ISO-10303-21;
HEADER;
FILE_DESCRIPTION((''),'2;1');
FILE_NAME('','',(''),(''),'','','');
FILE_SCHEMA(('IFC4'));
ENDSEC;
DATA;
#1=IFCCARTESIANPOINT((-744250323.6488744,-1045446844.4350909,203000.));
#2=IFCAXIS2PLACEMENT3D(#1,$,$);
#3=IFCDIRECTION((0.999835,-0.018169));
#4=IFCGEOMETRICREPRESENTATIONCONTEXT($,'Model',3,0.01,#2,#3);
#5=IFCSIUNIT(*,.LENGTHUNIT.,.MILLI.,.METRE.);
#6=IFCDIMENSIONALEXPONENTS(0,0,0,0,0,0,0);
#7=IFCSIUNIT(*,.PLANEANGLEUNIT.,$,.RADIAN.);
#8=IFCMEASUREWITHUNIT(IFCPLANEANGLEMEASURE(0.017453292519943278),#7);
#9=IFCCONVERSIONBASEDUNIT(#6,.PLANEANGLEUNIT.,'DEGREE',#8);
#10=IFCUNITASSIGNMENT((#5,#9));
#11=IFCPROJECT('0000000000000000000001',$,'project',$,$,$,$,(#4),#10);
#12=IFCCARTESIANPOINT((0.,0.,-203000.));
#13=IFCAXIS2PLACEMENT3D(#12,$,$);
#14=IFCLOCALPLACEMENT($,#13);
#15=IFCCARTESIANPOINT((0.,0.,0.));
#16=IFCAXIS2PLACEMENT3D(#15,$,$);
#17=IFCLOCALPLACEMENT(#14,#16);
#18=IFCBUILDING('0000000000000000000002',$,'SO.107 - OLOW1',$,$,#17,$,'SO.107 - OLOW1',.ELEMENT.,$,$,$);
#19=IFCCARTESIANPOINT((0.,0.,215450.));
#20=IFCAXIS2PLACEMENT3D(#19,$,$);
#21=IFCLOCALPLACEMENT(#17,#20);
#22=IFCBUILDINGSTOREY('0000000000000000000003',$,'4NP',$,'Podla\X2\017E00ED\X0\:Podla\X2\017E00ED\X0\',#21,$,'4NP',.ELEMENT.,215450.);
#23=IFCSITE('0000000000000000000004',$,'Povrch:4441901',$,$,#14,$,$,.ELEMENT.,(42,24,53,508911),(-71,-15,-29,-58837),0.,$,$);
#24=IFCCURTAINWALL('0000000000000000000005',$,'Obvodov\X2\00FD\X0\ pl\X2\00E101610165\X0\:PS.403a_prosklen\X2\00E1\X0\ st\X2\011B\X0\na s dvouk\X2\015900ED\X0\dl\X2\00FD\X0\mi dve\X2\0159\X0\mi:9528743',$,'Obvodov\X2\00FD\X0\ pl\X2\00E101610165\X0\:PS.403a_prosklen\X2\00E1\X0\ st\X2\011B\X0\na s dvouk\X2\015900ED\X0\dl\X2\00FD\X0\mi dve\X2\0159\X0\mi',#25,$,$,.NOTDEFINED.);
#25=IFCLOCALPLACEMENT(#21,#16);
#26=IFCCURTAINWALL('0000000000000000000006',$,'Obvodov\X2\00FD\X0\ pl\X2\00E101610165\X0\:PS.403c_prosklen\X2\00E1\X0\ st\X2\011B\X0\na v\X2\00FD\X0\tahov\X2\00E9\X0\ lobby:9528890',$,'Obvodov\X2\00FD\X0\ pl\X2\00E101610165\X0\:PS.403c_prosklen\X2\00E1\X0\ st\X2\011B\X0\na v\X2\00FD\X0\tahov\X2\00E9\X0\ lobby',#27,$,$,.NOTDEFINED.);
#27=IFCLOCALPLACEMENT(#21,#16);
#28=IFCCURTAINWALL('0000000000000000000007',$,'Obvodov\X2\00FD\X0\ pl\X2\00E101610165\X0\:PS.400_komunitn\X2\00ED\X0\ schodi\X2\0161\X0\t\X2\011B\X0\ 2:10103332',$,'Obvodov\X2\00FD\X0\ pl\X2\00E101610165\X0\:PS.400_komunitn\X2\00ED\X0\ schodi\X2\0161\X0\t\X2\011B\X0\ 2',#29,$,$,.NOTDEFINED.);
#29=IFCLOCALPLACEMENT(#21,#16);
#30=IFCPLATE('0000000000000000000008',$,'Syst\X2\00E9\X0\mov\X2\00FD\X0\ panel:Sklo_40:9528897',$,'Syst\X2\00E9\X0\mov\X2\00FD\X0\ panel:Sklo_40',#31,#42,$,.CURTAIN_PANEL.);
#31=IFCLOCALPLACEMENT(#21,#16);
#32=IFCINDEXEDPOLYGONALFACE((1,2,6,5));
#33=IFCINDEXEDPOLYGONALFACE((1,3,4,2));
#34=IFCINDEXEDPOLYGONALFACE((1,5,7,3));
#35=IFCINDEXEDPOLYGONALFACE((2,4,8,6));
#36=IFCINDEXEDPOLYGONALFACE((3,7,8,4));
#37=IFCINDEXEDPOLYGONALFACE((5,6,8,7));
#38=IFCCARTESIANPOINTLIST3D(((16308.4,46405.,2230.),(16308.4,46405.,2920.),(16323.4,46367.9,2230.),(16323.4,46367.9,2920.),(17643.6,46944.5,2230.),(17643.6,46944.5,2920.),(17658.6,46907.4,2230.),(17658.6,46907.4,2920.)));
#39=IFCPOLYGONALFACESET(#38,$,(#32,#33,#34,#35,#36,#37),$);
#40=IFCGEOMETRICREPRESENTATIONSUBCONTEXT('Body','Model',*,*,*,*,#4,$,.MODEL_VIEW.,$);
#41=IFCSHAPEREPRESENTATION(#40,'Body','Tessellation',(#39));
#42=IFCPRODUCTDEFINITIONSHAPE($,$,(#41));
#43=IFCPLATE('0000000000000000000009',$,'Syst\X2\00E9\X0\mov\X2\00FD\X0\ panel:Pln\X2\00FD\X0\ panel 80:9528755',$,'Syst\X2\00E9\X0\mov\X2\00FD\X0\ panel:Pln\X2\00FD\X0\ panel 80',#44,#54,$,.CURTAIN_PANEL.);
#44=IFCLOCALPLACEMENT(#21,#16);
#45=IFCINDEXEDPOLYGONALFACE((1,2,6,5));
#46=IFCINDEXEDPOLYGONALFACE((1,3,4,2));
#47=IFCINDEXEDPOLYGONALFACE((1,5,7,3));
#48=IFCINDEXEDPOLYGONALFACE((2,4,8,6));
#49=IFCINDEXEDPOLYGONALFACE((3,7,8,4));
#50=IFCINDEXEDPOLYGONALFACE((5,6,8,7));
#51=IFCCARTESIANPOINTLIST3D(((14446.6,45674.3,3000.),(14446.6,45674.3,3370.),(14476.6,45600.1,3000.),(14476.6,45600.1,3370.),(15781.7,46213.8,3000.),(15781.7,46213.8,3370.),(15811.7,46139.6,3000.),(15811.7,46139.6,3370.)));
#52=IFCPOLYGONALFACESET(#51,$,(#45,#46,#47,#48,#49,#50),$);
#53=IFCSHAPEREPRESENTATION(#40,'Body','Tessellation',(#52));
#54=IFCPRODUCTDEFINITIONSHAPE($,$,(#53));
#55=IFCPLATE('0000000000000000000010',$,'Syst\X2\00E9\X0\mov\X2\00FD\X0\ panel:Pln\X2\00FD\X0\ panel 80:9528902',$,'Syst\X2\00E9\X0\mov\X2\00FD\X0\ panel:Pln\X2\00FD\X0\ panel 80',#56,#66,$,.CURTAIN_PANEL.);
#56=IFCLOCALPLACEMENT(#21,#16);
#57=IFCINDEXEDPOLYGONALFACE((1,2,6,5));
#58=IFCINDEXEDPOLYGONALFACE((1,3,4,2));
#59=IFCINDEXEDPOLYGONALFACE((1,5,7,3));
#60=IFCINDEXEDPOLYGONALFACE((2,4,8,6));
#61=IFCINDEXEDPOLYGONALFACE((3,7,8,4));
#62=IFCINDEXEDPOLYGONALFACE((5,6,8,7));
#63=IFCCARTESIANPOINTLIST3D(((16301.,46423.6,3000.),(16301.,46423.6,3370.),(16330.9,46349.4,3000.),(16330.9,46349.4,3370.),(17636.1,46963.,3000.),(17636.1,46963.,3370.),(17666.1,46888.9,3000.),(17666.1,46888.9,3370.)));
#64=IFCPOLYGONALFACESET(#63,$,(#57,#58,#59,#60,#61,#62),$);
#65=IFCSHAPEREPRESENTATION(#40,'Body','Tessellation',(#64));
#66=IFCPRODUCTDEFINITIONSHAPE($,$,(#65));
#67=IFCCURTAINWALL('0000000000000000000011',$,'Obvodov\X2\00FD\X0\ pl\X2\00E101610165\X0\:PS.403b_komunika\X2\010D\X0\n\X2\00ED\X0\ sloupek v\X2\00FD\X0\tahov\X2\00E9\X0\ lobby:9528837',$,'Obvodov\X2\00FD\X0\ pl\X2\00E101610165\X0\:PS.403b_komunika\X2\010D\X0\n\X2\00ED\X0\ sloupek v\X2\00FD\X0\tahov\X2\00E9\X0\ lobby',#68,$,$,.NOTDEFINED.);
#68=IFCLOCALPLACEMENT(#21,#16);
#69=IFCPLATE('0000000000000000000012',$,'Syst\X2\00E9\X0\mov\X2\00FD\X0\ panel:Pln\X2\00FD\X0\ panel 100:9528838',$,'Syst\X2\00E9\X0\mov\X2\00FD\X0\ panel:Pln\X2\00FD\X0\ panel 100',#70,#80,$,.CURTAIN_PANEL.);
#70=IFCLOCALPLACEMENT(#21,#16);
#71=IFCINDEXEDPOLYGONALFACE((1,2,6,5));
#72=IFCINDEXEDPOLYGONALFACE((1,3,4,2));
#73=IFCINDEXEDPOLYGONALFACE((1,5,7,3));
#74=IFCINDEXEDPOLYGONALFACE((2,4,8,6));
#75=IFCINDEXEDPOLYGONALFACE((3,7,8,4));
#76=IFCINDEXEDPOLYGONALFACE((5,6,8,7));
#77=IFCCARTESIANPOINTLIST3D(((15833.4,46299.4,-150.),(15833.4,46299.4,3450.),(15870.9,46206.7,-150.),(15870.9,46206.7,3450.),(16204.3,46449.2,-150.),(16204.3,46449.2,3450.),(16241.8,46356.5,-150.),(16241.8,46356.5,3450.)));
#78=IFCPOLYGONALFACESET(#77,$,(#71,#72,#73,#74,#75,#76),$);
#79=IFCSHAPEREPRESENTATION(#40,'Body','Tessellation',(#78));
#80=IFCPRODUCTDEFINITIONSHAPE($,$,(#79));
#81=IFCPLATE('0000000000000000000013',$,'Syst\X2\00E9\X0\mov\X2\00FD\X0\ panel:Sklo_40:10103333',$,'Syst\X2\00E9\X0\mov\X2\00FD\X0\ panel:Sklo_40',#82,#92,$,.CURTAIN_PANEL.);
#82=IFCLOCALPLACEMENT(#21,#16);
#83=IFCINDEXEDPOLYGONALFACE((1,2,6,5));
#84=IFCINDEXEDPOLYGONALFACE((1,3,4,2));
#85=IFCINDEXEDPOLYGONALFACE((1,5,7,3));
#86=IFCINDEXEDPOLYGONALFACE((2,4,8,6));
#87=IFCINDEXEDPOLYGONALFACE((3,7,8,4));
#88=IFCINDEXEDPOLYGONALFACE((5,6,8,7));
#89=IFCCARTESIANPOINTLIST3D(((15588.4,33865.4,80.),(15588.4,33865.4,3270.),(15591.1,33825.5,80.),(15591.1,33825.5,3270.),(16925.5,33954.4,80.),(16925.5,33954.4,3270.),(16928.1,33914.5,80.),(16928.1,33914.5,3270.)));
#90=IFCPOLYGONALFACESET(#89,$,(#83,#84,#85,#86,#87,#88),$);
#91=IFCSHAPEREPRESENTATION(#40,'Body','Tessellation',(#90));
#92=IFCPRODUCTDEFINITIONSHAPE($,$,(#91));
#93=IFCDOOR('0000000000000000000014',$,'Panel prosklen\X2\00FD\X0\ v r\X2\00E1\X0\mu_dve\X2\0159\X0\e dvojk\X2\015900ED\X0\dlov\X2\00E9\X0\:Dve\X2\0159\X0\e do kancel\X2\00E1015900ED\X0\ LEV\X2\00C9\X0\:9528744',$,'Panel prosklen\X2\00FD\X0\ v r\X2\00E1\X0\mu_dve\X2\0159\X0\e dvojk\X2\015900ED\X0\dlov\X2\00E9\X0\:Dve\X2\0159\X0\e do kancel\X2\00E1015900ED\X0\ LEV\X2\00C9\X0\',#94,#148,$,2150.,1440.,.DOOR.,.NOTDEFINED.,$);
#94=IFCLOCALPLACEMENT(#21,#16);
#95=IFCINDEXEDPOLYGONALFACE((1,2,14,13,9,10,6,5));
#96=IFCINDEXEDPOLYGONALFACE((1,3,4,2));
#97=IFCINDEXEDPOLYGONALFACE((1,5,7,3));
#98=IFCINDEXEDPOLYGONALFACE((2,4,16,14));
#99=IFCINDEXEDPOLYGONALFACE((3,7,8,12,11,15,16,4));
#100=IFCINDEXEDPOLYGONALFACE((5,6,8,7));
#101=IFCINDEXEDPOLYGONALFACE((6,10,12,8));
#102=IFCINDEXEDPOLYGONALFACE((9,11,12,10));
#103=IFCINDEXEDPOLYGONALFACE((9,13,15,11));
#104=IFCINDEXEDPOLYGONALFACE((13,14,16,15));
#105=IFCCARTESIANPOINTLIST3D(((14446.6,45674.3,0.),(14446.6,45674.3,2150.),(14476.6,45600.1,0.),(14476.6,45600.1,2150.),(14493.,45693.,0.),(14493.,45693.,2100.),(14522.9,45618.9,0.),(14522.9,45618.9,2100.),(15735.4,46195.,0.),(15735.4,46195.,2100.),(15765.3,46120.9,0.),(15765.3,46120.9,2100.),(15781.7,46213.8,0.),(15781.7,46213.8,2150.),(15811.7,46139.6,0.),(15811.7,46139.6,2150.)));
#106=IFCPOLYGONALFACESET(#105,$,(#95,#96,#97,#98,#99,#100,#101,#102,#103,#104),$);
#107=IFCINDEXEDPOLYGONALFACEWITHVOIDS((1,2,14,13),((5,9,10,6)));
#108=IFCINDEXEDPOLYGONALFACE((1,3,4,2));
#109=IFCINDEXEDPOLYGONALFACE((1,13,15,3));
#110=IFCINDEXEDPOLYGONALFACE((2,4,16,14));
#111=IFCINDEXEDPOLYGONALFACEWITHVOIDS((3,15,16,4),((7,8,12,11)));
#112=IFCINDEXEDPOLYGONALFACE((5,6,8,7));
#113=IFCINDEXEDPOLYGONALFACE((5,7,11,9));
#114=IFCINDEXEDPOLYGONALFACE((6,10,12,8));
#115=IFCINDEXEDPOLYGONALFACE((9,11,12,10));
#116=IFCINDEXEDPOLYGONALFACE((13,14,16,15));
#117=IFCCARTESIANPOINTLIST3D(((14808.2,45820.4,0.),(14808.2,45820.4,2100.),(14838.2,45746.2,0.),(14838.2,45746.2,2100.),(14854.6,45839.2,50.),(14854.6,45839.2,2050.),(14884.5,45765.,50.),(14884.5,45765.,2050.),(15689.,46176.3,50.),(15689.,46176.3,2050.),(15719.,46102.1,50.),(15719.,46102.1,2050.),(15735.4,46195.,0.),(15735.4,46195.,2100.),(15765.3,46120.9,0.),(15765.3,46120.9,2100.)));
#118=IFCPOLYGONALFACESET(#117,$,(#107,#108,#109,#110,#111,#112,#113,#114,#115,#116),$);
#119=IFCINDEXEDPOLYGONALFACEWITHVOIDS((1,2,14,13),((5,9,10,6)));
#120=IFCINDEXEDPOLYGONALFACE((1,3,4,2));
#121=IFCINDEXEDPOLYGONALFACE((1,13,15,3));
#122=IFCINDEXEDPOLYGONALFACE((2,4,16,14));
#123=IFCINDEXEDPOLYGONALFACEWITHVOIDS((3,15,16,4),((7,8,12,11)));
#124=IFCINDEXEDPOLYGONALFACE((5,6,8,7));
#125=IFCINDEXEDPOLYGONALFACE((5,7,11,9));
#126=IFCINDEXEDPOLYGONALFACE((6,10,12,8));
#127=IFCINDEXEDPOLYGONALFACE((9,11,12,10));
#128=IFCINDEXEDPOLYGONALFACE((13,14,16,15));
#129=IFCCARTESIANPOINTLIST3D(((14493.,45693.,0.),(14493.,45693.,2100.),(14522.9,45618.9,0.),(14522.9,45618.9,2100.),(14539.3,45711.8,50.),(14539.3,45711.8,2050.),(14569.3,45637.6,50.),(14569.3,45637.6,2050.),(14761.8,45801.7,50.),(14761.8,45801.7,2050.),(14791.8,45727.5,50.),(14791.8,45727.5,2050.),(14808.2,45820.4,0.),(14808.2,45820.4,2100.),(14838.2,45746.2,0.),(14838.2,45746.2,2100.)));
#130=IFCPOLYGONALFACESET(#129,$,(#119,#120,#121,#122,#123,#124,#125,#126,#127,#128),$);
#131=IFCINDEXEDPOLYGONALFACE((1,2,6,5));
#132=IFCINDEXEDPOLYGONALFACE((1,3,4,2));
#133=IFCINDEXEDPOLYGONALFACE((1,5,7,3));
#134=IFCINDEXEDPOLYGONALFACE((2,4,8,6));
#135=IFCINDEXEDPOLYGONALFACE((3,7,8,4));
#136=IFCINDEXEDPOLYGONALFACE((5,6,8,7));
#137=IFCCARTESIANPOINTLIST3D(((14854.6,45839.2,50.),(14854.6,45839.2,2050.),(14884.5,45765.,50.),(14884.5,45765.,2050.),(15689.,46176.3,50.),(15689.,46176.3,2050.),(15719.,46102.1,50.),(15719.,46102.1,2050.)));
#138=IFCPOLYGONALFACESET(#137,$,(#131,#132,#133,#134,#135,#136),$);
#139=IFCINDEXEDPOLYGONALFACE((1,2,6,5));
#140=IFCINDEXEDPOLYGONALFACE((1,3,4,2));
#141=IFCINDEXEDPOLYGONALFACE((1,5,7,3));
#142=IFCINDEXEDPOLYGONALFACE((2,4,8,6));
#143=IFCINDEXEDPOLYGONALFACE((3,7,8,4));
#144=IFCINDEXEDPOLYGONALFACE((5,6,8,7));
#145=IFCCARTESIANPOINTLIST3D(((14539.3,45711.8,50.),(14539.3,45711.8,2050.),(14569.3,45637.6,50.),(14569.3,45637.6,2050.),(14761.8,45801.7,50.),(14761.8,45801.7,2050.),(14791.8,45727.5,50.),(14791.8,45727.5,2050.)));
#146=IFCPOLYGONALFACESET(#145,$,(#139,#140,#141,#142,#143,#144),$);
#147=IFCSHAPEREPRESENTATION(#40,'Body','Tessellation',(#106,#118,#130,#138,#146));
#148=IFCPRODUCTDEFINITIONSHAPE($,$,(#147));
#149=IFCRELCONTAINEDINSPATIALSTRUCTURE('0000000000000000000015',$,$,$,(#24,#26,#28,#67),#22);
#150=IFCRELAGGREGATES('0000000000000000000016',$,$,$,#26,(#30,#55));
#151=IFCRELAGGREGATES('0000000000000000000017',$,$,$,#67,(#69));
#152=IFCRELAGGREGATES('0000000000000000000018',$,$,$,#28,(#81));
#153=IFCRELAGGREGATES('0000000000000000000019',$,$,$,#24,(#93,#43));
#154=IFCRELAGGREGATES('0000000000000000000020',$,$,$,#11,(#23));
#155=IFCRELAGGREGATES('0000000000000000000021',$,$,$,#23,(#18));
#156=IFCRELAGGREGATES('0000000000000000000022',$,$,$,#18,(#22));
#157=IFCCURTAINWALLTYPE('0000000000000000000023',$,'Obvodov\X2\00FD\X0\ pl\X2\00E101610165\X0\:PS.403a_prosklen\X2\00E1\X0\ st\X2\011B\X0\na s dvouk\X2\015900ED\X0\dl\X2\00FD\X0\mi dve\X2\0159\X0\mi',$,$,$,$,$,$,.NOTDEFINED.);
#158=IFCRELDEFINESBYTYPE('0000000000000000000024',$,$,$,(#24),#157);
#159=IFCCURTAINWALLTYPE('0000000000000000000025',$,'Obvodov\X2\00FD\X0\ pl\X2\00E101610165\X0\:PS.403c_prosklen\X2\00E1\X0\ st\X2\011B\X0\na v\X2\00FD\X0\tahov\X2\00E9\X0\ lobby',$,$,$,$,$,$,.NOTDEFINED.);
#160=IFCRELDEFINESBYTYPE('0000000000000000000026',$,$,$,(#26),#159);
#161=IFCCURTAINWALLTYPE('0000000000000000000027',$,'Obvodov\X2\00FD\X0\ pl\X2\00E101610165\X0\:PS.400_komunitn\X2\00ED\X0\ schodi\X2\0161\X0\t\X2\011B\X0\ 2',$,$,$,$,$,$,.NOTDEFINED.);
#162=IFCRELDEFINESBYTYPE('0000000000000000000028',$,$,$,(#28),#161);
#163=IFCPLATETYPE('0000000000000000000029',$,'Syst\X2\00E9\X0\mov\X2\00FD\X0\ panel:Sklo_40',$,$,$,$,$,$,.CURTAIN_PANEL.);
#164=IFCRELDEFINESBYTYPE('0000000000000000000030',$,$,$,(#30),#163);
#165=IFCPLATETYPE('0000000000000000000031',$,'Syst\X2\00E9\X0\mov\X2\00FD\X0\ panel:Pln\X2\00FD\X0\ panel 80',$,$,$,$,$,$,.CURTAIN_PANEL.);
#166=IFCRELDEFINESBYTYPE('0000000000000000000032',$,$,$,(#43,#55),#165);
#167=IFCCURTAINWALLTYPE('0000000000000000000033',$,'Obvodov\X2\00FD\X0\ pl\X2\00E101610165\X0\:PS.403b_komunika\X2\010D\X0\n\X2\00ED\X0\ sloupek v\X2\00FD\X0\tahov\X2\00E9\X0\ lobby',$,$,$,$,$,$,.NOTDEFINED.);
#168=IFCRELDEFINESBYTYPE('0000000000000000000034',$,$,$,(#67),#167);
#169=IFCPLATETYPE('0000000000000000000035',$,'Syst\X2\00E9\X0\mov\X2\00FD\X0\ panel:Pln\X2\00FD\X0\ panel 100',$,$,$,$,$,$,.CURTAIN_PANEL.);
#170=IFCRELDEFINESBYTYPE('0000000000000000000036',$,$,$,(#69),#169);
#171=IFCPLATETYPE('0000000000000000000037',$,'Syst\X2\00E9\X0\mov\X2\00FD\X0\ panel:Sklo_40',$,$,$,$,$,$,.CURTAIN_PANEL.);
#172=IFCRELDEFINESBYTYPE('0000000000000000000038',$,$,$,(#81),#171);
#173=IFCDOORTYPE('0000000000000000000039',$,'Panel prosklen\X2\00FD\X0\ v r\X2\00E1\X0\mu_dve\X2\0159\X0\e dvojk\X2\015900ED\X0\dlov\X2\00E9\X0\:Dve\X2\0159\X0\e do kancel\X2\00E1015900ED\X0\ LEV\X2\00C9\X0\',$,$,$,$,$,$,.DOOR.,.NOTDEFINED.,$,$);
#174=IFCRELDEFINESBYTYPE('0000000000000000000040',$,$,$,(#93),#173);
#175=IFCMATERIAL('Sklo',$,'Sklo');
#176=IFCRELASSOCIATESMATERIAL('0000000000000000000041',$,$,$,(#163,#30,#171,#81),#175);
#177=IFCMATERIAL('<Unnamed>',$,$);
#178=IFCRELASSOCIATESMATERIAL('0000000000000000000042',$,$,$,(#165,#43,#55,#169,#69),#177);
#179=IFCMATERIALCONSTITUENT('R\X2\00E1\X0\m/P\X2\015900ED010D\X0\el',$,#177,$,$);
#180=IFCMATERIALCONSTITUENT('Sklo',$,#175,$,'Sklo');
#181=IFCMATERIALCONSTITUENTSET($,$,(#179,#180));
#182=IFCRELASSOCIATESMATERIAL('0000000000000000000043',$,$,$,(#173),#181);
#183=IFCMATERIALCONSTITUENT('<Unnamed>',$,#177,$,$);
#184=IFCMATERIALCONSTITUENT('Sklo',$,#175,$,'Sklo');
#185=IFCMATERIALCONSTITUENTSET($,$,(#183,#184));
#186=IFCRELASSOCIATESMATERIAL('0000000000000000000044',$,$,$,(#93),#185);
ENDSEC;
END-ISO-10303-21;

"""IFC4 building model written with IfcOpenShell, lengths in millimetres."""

from ifc_helpers import new_model, entity, si_unit, converted_unit, direction, frame, origin, place, context, subcontext, project, spatial, indexed_curve, outline, extrude, source, transform, mapped, material, constituent, constituent_set, type_object, type_shapes, element, aggregate, save


model = new_model("IFC4")

# Units and contexts
model_context = context("Model", 3, precision=0.01, world=frame((-744250323.6488744, -1045446844.4350909, 203000.0)), true_north=direction((0.999835, -0.018169)))
body_context = subcontext(model_context, "Body", "Model", "MODEL_VIEW")
ifc_project = project(units=[si_unit("LENGTHUNIT", "METRE", prefix="MILLI"), converted_unit("PLANEANGLEUNIT", "DEGREE", entity("IfcPlaneAngleMeasure", 0.017453292519943278), si_unit("PLANEANGLEUNIT", "RADIAN"), dimensions=[0, 0, 0, 0, 0, 0, 0])], contexts=[model_context])

# Site, building, storey
site_placement = place(None, frame((0.0, 0.0, -203000.0)))
site = spatial("IfcSite", under=ifc_project, at=site_placement, Name="Povrch:4441901", CompositionType="ELEMENT", RefLatitude=(42, 24, 53, 508911), RefLongitude=(-71, -15, -29, -58837), RefElevation=0.0)
building_placement = place(site_placement, origin())
building = spatial("IfcBuilding", under=site, at=building_placement, Name="SO.107 - OLOW1", LongName="SO.107 - OLOW1", CompositionType="ELEMENT")
storey_placement = place(building_placement, frame((0.0, 0.0, 215450.0)))
storey = spatial("IfcBuildingStorey", under=building, at=storey_placement, Name="4NP", ObjectType="Podlaží:Podlaží", LongName="4NP", CompositionType="ELEMENT", Elevation=215450.0)

# Curtain walls
curtain_wall_type_1 = type_object("IfcCurtainWallType", Name="Obvodový plášť:PS.403a_prosklená stěna s dvoukřídlými dveřmi", PredefinedType="NOTDEFINED")
curtain_wall_1_placement = place(storey_placement, frame((0.0, 0.0, -215450.0)))
curtain_wall_1 = element("IfcCurtainWall", 1, at=curtain_wall_1_placement, inside=storey, type_object=curtain_wall_type_1, Name="Obvodový plášť:PS.403a_prosklená stěna s dvoukřídlými dveřmi:9528743", ObjectType="Obvodový plášť:PS.403a_prosklená stěna s dvoukřídlými dveřmi", PredefinedType="NOTDEFINED")
ifc_material_1 = material(Name="<Unnamed>")
curtain_wall_type_2 = type_object("IfcCurtainWallType", Name="Obvodový plášť:PS.403c_prosklená stěna výtahové lobby", PredefinedType="NOTDEFINED")
curtain_wall_2_placement = place(storey_placement, frame((0.0, 0.0, -215450.0)))
curtain_wall_2 = element("IfcCurtainWall", 2, at=curtain_wall_2_placement, inside=storey, type_object=curtain_wall_type_2, Name="Obvodový plášť:PS.403c_prosklená stěna výtahové lobby:9528890", ObjectType="Obvodový plášť:PS.403c_prosklená stěna výtahové lobby", PredefinedType="NOTDEFINED")

# Curtain wall
curtain_wall_type_3 = type_object("IfcCurtainWallType", Name="Obvodový plášť:PS.400_komunitní schodiště 2", PredefinedType="NOTDEFINED")
curtain_wall_3_placement = place(storey_placement, frame((0.0, 0.0, -215450.0)))
curtain_wall_3 = element("IfcCurtainWall", 3, at=curtain_wall_3_placement, inside=storey, type_object=curtain_wall_type_3, Name="Obvodový plášť:PS.400_komunitní schodiště 2:10103332", ObjectType="Obvodový plášť:PS.400_komunitní schodiště 2", PredefinedType="NOTDEFINED")

# Plates
ifc_material_2 = material(Name="Sklo", Category="Sklo")
plate_type_1 = type_object("IfcPlateType", Name="Systémový panel:Sklo_40", PredefinedType="CURTAIN_PANEL", material=ifc_material_2)
shared_shape_1 = source(origin(), body_context, "Body", "SweptSolid", [
    extrude(outline(indexed_curve([(-20.0, -720.0), (20.0, -720.0), (20.0, 720.0), (-20.0, 720.0), (-20.0, -720.0)], self_intersect=False)), frame((0.0, 0.0, 0.0), z_axis=(0.0, 0.0, 1.0), x_axis=(0.0, 1.0, 0.0)), (0.0, 0.0, 1.0), 690.0),
])
type_shapes(plate_type_1, [shared_shape_1])
plate_1_placement = place(curtain_wall_2_placement, frame((16983.5, 46656.2, 217680.0), z_axis=(0.0, 0.0, 1.0), x_axis=(0.927176, 0.374626, 0.0)))
plate_1 = element("IfcPlate", 4, at=plate_1_placement, type_object=plate_type_1, material=ifc_material_2, Name="Systémový panel:Sklo_40:9528897", ObjectType="Systémový panel:Sklo_40", PredefinedType="CURTAIN_PANEL", context=body_context, shape_type="MappedRepresentation", body=[
    mapped(shared_shape_1, transform((0.0, 0.0, 0.0), scale=1.0)),
])
plate_type_2 = type_object("IfcPlateType", Name="Systémový panel:Plný panel 80", PredefinedType="CURTAIN_PANEL", material=ifc_material_1)
shared_shape_2 = source(origin(), body_context, "Body", "SweptSolid", [
    extrude(outline(indexed_curve([(-40.0, -720.0), (40.0, -720.0), (40.0, 720.0), (-40.0, 720.0), (-40.0, -720.0)], self_intersect=False)), frame((0.0, 0.0, 0.0), z_axis=(0.0, 0.0, 1.0), x_axis=(0.0, 1.0, 0.0)), (0.0, 0.0, 1.0), 370.0),
])
type_shapes(plate_type_2, [shared_shape_2])
plate_2_placement = place(curtain_wall_1_placement, frame((15129.2, 45907.0, 218450.0), z_axis=(0.0, 0.0, 1.0), x_axis=(0.927176, 0.374626, 0.0)))
plate_2 = element("IfcPlate", 5, at=plate_2_placement, type_object=plate_type_2, material=ifc_material_1, Name="Systémový panel:Plný panel 80:9528755", ObjectType="Systémový panel:Plný panel 80", PredefinedType="CURTAIN_PANEL", context=body_context, shape_type="MappedRepresentation", body=[
    mapped(shared_shape_2, transform((0.0, 0.0, 0.0), scale=1.0)),
])
plate_3_placement = place(curtain_wall_2_placement, frame((16983.5, 46656.2, 218450.0), z_axis=(0.0, 0.0, 1.0), x_axis=(0.927176, 0.374626, 0.0)))
plate_3 = element("IfcPlate", 6, at=plate_3_placement, type_object=plate_type_2, material=ifc_material_1, Name="Systémový panel:Plný panel 80:9528902", ObjectType="Systémový panel:Plný panel 80", PredefinedType="CURTAIN_PANEL", context=body_context, shape_type="MappedRepresentation", body=[
    mapped(shared_shape_2, transform((0.0, 0.0, 0.0), scale=1.0)),
])
aggregate(curtain_wall_2, [plate_1, plate_3])

# Curtain wall, plate
curtain_wall_type_4 = type_object("IfcCurtainWallType", Name="Obvodový plášť:PS.403b_komunikační sloupek výtahové lobby", PredefinedType="NOTDEFINED")
curtain_wall_4_placement = place(storey_placement, frame((0.0, 0.0, -215450.0)))
curtain_wall_4 = element("IfcCurtainWall", 7, at=curtain_wall_4_placement, inside=storey, type_object=curtain_wall_type_4, Name="Obvodový plášť:PS.403b_komunikační sloupek výtahové lobby:9528837", ObjectType="Obvodový plášť:PS.403b_komunikační sloupek výtahové lobby", PredefinedType="NOTDEFINED")
plate_type_3 = type_object("IfcPlateType", Name="Systémový panel:Plný panel 100", PredefinedType="CURTAIN_PANEL", material=ifc_material_1)
shared_shape_3 = source(origin(), body_context, "Body", "SweptSolid", [
    extrude(outline(indexed_curve([(-50.0, -200.0), (50.0, -200.0), (50.0, 200.0), (-50.0, 200.0), (-50.0, -200.0)], self_intersect=False)), frame((0.0, 50.0, 0.0), z_axis=(0.0, 0.0, 1.0), x_axis=(0.0, 1.0, 0.0)), (0.0, 0.0, 1.0), 3600.0),
])
type_shapes(plate_type_3, [shared_shape_3])
plate_4_placement = place(curtain_wall_4_placement, frame((16056.3, 46281.6, 215300.0), z_axis=(0.0, 0.0, 1.0), x_axis=(0.927176, 0.374626, 0.0)))
plate_4 = element("IfcPlate", 8, at=plate_4_placement, type_object=plate_type_3, material=ifc_material_1, Name="Systémový panel:Plný panel 100:9528838", ObjectType="Systémový panel:Plný panel 100", PredefinedType="CURTAIN_PANEL", context=body_context, shape_type="MappedRepresentation", body=[
    mapped(shared_shape_3, transform((0.0, 0.0, 0.0), scale=1.0)),
])
aggregate(curtain_wall_4, [plate_4])

# Plate
plate_type_4 = type_object("IfcPlateType", Name="Systémový panel:Sklo_40", PredefinedType="CURTAIN_PANEL", material=ifc_material_2)
shared_shape_4 = source(origin(), body_context, "Body", "SweptSolid", [
    extrude(outline(indexed_curve([(-20.0, -670.0), (20.0, -670.0), (20.0, 670.0), (-20.0, 670.0), (-20.0, -670.0)], self_intersect=False)), frame((0.0, 0.0, 0.0), z_axis=(0.0, 0.0, 1.0), x_axis=(0.0, 1.0, 0.0)), (0.0, 0.0, 1.0), 3190.0),
])
type_shapes(plate_type_4, [shared_shape_4])
plate_5_placement = place(curtain_wall_3_placement, frame((16258.3, 33889.9, 215530.0), z_axis=(0.0, 0.0, 1.0), x_axis=(-0.997792, -0.066409, 0.0)))
plate_5 = element("IfcPlate", 9, at=plate_5_placement, type_object=plate_type_4, material=ifc_material_2, Name="Systémový panel:Sklo_40:10103333", ObjectType="Systémový panel:Sklo_40", PredefinedType="CURTAIN_PANEL", context=body_context, shape_type="MappedRepresentation", body=[
    mapped(shared_shape_4, transform((0.0, 0.0, 0.0), scale=1.0)),
])
aggregate(curtain_wall_3, [plate_5])

# Door
ifc_constituent_1 = constituent(ifc_material_1, Name="<Unnamed>")
ifc_constituent_2 = constituent(ifc_material_2, Name="Sklo", Category="Sklo")
ifc_constituent_set_1 = constituent_set(constituents=[ifc_constituent_1, ifc_constituent_2])
ifc_constituent_3 = constituent(ifc_material_1, Name="Rám/Příčel")
ifc_constituent_4 = constituent(ifc_material_2, Name="Sklo", Category="Sklo")
ifc_constituent_set_2 = constituent_set(constituents=[ifc_constituent_3, ifc_constituent_4])
door_type = type_object("IfcDoorType", Name="Panel prosklený v rámu_dveře dvojkřídlové:Dveře do kanceláří LEVÉ", OperationType="NOTDEFINED", PredefinedType="DOOR", material=ifc_constituent_set_2)
shared_shape_5 = source(origin(), body_context, "Body", "SweptSolid", [
    extrude(outline(indexed_curve([(-720.0, -1087.5), (720.0, -1087.5), (720.0, 1062.5), (670.0, 1062.5), (670.0, -1037.5), (-670.0, -1037.5), (-670.0, 1062.5), (-720.0, 1062.5), (-720.0, -1087.5)], self_intersect=False)), frame((0.0, 40.0, 1062.5), z_axis=(0.0, -1.0, 0.0), x_axis=(-1.0, 0.0, 0.0)), (0.0, 0.0, 1.0), 80.0),
    extrude(outline(indexed_curve([(-1050.0, -500.0), (1050.0, -500.0), (1050.0, 500.0), (-1050.0, 500.0), (-1050.0, -500.0)], self_intersect=False), holes=[indexed_curve([(-1000.0, -450.0), (-1000.0, 450.0), (1000.0, 450.0), (1000.0, -450.0), (-1000.0, -450.0)], self_intersect=False)]), frame((-170.0, 40.0, 1050.0), z_axis=(0.0, -1.0, 0.0), x_axis=(0.0, 0.0, -1.0)), (0.0, 0.0, 1.0), 80.0),
    extrude(outline(indexed_curve([(-1050.0, -170.0), (1050.0, -170.0), (1050.0, 170.0), (-1050.0, 170.0), (-1050.0, -170.0)], self_intersect=False), holes=[indexed_curve([(-1000.0, -120.0), (-1000.0, 120.0), (1000.0, 120.0), (1000.0, -120.0), (-1000.0, -120.0)], self_intersect=False)]), frame((500.0, 40.0, 1050.0), z_axis=(0.0, -1.0, 0.0), x_axis=(0.0, 0.0, -1.0)), (0.0, 0.0, 1.0), 80.0),
    extrude(outline(indexed_curve([(-450.0, -40.0), (450.0, -40.0), (450.0, 40.0), (-450.0, 40.0), (-450.0, -40.0)], self_intersect=False)), frame((-170.0, 0.0, 50.0)), (0.0, 0.0, 1.0), 2000.0),
    extrude(outline(indexed_curve([(-120.0, -40.0), (120.0, -40.0), (120.0, 40.0), (-120.0, 40.0), (-120.0, -40.0)], self_intersect=False)), frame((500.0, 0.0, 50.0)), (0.0, 0.0, 1.0), 2000.0),
])
type_shapes(door_type, [shared_shape_5])
door_placement = place(curtain_wall_1_placement, frame((15129.2, 45907.0, 215450.0), z_axis=(0.0, 0.0, 1.0), x_axis=(-0.927176, -0.374626, 0.0)))
door = element("IfcDoor", 10, at=door_placement, type_object=door_type, material=ifc_constituent_set_1, Name="Panel prosklený v rámu_dveře dvojkřídlové:Dveře do kanceláří LEVÉ:9528744", ObjectType="Panel prosklený v rámu_dveře dvojkřídlové:Dveře do kanceláří LEVÉ", OperationType="NOTDEFINED", OverallHeight=2150.0, OverallWidth=1440.0, PredefinedType="DOOR", context=body_context, shape_type="MappedRepresentation", body=[
    mapped(shared_shape_5, transform((0.0, 0.0, 0.0), scale=1.0)),
])
aggregate(curtain_wall_1, [door, plate_2])

save(model, "model.ifc")
